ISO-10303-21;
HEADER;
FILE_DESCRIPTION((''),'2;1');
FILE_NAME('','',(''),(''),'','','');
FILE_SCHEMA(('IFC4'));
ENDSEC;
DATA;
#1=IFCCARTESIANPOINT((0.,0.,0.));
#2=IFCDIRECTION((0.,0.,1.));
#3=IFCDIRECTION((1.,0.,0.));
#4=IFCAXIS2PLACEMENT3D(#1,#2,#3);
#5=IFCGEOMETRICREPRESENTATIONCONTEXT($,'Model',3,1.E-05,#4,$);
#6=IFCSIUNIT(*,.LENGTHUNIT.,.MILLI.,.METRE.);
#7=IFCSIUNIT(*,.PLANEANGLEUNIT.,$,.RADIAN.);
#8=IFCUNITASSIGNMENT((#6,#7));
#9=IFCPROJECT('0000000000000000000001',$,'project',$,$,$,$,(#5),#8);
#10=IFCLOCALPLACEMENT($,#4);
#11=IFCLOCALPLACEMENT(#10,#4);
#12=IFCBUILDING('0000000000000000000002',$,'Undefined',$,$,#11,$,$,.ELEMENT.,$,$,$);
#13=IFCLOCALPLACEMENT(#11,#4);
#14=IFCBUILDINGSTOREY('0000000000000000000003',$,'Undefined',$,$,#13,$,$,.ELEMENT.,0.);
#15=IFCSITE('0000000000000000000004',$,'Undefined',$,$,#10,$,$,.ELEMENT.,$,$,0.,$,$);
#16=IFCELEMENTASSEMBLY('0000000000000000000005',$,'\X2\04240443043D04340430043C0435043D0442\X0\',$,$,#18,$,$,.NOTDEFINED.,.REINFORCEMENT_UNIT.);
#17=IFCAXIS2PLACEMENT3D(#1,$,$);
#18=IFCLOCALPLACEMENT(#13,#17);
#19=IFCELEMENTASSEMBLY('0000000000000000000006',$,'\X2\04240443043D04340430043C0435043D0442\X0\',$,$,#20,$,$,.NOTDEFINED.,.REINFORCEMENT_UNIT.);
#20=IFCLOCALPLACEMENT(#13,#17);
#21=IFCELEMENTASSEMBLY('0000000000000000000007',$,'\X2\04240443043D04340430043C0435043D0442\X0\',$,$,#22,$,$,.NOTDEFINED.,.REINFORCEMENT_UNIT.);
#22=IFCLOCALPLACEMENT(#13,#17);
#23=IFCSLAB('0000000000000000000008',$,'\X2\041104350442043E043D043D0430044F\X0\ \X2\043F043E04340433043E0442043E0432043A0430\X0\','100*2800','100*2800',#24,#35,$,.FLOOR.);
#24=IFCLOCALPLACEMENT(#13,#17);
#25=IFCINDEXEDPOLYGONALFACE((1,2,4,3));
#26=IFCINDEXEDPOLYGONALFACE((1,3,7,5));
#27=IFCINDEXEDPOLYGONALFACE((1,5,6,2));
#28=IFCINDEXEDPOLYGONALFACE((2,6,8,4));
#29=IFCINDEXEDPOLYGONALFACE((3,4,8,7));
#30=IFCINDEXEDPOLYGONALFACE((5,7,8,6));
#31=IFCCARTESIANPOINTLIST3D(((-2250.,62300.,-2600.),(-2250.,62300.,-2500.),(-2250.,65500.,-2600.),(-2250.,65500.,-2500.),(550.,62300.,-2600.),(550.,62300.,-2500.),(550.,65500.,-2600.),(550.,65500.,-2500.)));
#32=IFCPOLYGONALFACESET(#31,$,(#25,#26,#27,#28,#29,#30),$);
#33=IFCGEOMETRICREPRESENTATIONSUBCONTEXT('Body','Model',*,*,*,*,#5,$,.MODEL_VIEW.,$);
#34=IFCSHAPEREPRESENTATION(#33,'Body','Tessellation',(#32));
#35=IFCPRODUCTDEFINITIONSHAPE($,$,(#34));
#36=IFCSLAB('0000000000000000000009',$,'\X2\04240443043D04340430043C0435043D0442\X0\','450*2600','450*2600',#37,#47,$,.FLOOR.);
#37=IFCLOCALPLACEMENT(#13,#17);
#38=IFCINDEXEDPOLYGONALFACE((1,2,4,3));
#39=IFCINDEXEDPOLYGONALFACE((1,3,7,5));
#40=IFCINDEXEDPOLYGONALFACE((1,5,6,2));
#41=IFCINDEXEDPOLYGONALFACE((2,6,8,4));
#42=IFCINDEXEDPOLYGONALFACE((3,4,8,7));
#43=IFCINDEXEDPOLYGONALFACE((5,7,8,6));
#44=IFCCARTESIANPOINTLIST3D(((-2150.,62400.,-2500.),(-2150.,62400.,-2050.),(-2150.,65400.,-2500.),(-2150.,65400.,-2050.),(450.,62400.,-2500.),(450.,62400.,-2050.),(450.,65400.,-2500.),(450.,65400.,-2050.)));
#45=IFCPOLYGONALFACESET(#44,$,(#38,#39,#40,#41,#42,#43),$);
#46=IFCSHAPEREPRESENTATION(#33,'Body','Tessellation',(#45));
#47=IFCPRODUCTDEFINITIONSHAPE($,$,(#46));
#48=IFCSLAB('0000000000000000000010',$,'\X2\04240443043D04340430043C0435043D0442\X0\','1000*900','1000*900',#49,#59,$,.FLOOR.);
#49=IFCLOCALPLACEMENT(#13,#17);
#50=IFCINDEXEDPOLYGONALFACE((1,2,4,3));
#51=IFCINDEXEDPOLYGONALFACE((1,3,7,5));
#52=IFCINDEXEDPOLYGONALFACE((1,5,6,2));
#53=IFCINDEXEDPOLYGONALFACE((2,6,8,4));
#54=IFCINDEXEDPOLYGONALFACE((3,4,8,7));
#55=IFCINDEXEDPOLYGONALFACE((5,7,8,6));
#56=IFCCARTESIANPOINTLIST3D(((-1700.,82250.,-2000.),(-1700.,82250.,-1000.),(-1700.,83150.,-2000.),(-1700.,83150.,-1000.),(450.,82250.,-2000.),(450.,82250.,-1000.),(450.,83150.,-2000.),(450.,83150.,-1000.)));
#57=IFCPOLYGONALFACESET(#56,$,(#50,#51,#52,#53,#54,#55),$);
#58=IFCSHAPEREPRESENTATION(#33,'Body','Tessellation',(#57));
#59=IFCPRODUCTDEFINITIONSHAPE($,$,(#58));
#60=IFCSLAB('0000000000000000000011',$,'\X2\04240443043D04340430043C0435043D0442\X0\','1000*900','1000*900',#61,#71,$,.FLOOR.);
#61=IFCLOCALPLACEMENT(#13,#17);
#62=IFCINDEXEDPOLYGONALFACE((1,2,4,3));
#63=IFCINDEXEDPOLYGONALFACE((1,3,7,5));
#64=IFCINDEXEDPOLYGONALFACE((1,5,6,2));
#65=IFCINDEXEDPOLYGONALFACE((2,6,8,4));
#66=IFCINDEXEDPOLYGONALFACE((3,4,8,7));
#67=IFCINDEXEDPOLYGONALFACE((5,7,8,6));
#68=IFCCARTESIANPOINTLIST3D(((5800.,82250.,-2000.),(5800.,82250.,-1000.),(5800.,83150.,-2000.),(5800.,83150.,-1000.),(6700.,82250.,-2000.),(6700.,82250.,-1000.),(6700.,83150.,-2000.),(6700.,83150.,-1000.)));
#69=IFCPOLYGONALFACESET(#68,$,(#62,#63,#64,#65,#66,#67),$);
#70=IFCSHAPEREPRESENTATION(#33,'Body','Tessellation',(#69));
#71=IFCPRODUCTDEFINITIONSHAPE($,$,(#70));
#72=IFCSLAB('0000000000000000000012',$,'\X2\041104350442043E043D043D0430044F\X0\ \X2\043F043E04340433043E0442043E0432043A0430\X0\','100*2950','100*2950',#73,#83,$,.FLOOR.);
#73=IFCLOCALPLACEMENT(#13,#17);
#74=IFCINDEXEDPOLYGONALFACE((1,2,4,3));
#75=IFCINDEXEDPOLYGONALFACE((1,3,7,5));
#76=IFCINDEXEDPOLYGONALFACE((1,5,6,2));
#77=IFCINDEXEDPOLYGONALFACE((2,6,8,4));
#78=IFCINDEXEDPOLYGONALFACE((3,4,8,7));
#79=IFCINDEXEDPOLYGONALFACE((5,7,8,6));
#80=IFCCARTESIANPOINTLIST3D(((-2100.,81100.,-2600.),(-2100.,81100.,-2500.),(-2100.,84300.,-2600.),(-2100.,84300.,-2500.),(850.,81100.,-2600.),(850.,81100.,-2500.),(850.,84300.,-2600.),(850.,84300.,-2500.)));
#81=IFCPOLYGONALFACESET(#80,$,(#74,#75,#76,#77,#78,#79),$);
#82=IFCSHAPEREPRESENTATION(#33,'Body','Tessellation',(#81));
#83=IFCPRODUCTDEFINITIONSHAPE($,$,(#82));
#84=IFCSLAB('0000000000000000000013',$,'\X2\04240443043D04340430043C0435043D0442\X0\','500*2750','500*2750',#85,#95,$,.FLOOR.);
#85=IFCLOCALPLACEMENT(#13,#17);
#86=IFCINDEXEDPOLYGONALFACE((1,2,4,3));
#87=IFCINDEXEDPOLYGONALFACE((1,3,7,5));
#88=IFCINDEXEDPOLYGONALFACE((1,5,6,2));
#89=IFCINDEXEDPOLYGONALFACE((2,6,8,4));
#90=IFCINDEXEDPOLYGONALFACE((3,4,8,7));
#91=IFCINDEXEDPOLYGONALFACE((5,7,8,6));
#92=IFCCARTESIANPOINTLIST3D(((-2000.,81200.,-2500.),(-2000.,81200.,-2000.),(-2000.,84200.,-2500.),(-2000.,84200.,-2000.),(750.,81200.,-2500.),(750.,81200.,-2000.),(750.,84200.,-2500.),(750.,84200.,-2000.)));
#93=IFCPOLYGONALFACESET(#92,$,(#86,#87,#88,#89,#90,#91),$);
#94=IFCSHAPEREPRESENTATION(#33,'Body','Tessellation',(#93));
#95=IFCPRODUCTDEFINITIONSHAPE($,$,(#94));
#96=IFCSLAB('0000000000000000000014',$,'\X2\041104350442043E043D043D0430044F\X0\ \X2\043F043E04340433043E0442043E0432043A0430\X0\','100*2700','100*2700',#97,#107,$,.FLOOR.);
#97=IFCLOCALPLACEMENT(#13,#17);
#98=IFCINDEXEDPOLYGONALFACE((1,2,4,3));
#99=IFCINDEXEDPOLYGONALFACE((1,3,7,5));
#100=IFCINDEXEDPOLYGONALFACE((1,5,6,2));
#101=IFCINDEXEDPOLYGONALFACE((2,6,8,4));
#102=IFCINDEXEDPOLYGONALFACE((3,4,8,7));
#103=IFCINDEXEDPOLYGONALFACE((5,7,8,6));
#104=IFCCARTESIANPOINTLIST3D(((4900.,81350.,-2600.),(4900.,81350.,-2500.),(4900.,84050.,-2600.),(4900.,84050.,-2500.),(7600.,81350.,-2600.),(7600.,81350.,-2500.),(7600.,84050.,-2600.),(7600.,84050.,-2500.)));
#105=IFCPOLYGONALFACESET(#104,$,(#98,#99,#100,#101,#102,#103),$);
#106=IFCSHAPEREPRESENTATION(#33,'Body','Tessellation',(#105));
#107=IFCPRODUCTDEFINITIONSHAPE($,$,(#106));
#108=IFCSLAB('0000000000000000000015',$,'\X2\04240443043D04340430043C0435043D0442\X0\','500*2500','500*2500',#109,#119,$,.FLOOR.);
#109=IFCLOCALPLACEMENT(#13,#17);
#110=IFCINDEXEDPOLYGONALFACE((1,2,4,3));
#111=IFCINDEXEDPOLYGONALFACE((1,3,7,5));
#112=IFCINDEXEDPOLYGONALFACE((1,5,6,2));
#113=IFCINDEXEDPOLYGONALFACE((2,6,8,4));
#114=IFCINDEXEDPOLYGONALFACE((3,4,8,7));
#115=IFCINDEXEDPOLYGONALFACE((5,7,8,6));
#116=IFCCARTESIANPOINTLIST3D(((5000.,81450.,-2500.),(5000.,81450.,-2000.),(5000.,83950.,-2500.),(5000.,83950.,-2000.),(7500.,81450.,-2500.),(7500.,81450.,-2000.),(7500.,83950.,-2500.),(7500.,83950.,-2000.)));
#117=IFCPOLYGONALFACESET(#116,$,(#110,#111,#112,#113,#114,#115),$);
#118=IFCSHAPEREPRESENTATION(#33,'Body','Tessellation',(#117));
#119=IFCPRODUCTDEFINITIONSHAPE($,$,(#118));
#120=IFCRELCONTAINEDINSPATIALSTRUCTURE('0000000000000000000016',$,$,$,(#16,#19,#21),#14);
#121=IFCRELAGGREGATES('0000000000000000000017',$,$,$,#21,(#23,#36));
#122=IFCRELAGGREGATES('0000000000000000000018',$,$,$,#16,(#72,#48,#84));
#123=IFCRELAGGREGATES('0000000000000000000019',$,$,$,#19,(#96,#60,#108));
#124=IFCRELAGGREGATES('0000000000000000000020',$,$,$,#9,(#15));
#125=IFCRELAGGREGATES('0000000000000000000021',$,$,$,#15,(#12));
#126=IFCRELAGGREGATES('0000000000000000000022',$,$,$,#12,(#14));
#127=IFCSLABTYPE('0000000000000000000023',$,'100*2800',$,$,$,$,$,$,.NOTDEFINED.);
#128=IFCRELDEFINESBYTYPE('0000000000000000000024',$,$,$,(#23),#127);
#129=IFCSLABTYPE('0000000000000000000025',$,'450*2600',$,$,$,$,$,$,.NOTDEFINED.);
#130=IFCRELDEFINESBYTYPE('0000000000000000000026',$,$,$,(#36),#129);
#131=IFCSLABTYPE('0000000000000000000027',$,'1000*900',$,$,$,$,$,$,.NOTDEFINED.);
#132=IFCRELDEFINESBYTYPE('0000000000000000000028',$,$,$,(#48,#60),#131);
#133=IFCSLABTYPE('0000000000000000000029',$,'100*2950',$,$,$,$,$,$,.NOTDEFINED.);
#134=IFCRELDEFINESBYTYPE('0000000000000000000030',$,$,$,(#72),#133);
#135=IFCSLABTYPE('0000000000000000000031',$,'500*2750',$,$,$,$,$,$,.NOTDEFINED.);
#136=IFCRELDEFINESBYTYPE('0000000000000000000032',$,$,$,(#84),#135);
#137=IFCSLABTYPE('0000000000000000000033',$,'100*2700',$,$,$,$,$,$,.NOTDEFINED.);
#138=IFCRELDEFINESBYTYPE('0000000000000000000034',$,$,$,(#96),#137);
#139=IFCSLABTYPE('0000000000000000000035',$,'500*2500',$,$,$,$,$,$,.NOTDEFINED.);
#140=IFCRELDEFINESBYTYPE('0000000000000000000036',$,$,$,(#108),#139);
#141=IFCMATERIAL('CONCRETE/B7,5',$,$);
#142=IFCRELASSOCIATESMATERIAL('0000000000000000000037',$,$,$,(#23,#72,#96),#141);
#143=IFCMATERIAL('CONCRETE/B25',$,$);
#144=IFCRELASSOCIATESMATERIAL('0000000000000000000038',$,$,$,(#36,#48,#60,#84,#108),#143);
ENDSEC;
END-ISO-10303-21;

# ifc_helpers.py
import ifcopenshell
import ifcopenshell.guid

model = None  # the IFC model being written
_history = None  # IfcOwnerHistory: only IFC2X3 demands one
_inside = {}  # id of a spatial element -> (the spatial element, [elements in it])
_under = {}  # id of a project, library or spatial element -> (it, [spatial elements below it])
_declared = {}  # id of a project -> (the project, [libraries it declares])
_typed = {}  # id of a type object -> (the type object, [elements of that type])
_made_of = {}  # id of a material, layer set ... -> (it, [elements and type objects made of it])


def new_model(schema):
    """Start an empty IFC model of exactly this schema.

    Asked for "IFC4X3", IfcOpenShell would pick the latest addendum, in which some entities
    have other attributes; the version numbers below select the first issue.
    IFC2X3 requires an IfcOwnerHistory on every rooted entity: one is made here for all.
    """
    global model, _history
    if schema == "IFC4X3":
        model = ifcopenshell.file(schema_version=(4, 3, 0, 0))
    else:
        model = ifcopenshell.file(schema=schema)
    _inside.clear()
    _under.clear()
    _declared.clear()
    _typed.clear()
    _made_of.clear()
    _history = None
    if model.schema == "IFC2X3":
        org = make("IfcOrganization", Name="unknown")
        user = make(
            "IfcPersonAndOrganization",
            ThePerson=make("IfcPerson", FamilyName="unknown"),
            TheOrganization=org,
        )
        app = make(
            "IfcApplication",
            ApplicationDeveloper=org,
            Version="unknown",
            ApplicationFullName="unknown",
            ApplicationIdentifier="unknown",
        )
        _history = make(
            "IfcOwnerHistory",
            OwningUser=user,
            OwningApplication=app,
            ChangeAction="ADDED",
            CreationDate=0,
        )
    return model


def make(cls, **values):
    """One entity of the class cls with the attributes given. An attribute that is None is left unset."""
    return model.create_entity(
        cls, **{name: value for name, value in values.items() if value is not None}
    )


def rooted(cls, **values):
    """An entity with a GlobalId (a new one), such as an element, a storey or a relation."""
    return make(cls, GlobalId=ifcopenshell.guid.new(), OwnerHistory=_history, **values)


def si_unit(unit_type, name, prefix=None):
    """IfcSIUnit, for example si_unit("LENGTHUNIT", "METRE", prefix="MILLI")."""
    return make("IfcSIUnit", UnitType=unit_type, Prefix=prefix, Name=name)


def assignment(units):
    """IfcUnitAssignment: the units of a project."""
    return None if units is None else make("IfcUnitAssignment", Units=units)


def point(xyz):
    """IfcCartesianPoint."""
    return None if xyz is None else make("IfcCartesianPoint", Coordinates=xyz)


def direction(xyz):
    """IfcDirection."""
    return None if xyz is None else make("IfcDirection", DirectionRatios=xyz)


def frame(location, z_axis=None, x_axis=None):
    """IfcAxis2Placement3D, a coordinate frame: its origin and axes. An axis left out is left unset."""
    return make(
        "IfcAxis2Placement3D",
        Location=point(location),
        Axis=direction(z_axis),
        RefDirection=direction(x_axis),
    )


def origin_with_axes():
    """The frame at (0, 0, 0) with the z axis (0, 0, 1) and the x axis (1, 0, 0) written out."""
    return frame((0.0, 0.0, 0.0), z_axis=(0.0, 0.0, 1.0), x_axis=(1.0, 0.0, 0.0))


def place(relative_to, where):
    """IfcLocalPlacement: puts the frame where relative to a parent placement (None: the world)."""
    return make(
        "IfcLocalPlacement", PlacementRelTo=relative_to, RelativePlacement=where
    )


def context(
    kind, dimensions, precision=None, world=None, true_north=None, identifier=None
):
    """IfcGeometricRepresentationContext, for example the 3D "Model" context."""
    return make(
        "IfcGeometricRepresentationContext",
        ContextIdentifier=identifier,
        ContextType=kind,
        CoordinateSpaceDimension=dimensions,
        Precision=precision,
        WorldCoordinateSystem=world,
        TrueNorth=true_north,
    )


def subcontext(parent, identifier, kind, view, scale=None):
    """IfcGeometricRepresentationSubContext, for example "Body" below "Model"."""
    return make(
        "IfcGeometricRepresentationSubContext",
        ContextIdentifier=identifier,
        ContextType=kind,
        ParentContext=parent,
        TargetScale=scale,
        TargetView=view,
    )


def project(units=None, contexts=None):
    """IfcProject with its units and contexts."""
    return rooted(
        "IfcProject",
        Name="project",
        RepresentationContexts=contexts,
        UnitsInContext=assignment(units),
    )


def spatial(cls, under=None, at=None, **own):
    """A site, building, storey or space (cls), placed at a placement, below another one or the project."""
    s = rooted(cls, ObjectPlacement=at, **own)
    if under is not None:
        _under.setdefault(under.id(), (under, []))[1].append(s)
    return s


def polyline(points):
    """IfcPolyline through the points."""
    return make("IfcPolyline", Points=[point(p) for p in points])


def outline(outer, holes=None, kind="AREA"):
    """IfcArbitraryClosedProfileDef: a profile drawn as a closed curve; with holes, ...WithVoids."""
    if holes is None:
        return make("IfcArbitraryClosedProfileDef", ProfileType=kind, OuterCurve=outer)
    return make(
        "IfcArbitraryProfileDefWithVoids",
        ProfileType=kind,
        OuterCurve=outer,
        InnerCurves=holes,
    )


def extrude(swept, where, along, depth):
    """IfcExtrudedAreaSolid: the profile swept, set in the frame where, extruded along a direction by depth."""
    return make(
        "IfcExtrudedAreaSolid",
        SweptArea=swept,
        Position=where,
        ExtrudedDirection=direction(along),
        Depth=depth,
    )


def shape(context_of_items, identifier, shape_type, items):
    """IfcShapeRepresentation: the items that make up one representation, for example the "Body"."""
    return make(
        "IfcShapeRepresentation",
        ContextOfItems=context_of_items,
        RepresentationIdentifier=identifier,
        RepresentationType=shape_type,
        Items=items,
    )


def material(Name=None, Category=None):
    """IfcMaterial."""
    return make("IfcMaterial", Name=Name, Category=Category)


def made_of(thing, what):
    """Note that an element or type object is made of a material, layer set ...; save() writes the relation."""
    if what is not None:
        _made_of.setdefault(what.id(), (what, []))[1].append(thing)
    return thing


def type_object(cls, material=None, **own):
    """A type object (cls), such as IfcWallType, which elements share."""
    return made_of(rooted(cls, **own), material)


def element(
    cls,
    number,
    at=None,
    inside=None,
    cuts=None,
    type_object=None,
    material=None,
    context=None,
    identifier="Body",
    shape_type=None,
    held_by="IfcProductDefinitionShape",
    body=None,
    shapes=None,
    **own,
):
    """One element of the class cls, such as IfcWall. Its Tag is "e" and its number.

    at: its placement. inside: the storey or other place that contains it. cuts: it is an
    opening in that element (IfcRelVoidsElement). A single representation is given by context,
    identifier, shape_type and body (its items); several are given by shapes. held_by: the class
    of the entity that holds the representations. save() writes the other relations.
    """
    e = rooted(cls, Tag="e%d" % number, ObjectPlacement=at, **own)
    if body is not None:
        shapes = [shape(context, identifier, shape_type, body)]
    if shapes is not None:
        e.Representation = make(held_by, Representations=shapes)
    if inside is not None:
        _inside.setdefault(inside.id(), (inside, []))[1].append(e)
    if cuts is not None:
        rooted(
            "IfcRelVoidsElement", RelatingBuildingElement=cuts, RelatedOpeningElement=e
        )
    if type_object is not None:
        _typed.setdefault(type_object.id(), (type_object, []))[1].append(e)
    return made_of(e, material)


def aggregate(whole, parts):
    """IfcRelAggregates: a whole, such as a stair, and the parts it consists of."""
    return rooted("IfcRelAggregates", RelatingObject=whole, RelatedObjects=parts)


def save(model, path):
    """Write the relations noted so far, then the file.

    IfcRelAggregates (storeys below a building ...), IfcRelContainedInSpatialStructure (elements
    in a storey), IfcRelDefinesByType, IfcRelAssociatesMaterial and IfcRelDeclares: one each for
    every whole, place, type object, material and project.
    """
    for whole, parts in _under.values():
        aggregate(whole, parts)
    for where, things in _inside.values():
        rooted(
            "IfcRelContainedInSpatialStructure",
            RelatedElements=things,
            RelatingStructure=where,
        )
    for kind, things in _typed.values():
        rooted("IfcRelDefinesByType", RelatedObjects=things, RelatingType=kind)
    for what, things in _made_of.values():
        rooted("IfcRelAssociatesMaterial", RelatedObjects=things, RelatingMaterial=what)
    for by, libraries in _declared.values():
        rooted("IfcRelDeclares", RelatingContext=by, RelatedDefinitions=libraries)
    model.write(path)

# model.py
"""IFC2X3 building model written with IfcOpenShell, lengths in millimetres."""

from ifc_helpers import new_model, si_unit, frame, origin_with_axes, place, context, subcontext, project, spatial, polyline, outline, extrude, material, type_object, element, aggregate, save


model = new_model("IFC2X3")

# Units and contexts
model_context = context("Model", 3, precision=1e-05, world=origin_with_axes())
body_context = subcontext(model_context, "Body", "Model", "MODEL_VIEW")
ifc_project = project(units=[si_unit("LENGTHUNIT", "METRE", prefix="MILLI"), si_unit("PLANEANGLEUNIT", "RADIAN")], contexts=[model_context])

# Site, building, storey
site_placement = place(None, origin_with_axes())
site = spatial("IfcSite", under=ifc_project, at=site_placement, Name="Undefined", CompositionType="ELEMENT", RefElevation=0.0)
building_placement = place(site_placement, origin_with_axes())
building = spatial("IfcBuilding", under=site, at=building_placement, Name="Undefined", CompositionType="ELEMENT")
storey_placement = place(building_placement, origin_with_axes())
storey = spatial("IfcBuildingStorey", under=building, at=storey_placement, Name="Undefined", CompositionType="ELEMENT", Elevation=0.0)

# Element assemblies
assembly_1_placement = place(storey_placement, origin_with_axes())
assembly_1 = element("IfcElementAssembly", 1, at=assembly_1_placement, inside=storey, Name="Фундамент", AssemblyPlace="NOTDEFINED", PredefinedType="REINFORCEMENT_UNIT")
ifc_material_1 = material(Name="CONCRETE/B25")
assembly_2_placement = place(storey_placement, origin_with_axes())
assembly_2 = element("IfcElementAssembly", 2, at=assembly_2_placement, inside=storey, Name="Фундамент", AssemblyPlace="NOTDEFINED", PredefinedType="REINFORCEMENT_UNIT")

# Shared definitions
ifc_material_2 = material(Name="CONCRETE/B7,5")

# Element assembly, slabs
assembly_3_placement = place(storey_placement, origin_with_axes())
assembly_3 = element("IfcElementAssembly", 3, at=assembly_3_placement, inside=storey, Name="Фундамент", AssemblyPlace="NOTDEFINED", PredefinedType="REINFORCEMENT_UNIT")
slab_type_1 = type_object("IfcSlabType", Name="100*2800", PredefinedType="NOTDEFINED")
slab_1_placement = place(assembly_3_placement, frame((-2250.0, 65500.0, -2550.0), z_axis=(0.0, 0.0, 1.0), x_axis=(0.0, -1.0, 0.0)))
slab_1 = element("IfcSlab", 4, at=slab_1_placement, type_object=slab_type_1, material=ifc_material_2, Name="Бетонная подготовка", Description="100*2800", ObjectType="100*2800", PredefinedType="FLOOR", context=body_context, shape_type="SweptSolid", body=[
    extrude(outline(polyline([(0.0, 0.0), (3200.0, 0.0), (3200.0, 2800.0), (0.0, 2800.0), (0.0, 0.0)])), frame((0.0, 0.0, -50.0), z_axis=(0.0, 0.0, 1.0), x_axis=(1.0, 0.0, 0.0)), (0.0, 0.0, 1.0), 100.0),
])
slab_type_2 = type_object("IfcSlabType", Name="450*2600", PredefinedType="NOTDEFINED")
slab_2_placement = place(assembly_3_placement, frame((-2150.0, 65400.0, -2275.0), z_axis=(0.0, 0.0, 1.0), x_axis=(0.0, -1.0, 0.0)))
slab_2 = element("IfcSlab", 5, at=slab_2_placement, type_object=slab_type_2, material=ifc_material_1, Name="Фундамент", Description="450*2600", ObjectType="450*2600", PredefinedType="FLOOR", context=body_context, shape_type="SweptSolid", body=[
    extrude(outline(polyline([(0.0, 0.0), (3000.0, 0.0), (3000.0, 2600.0), (0.0, 2600.0), (0.0, 0.0)])), frame((0.0, 0.0, -225.0), z_axis=(0.0, 0.0, 1.0), x_axis=(1.0, 0.0, 0.0)), (0.0, 0.0, 1.0), 450.0),
])
aggregate(assembly_3, [slab_1, slab_2])

# Slabs
slab_type_3 = type_object("IfcSlabType", Name="1000*900", PredefinedType="NOTDEFINED")
slab_3_placement = place(assembly_1_placement, frame((-1700.0, 83150.0, -1500.0), z_axis=(0.0, 0.0, 1.0), x_axis=(0.0, -1.0, 0.0)))
slab_3 = element("IfcSlab", 6, at=slab_3_placement, type_object=slab_type_3, material=ifc_material_1, Name="Фундамент", Description="1000*900", ObjectType="1000*900", PredefinedType="FLOOR", context=body_context, shape_type="SweptSolid", body=[
    extrude(outline(polyline([(0.0, 0.0), (900.0, 0.0), (900.0, 2150.0), (0.0, 2150.0), (0.0, 0.0)])), frame((0.0, 0.0, -500.0), z_axis=(0.0, 0.0, 1.0), x_axis=(1.0, 0.0, 0.0)), (0.0, 0.0, 1.0), 1000.0),
])
slab_4_placement = place(assembly_2_placement, frame((5800.0, 83150.0, -1500.0), z_axis=(0.0, 0.0, 1.0), x_axis=(0.0, -1.0, 0.0)))
slab_4 = element("IfcSlab", 7, at=slab_4_placement, type_object=slab_type_3, material=ifc_material_1, Name="Фундамент", Description="1000*900", ObjectType="1000*900", PredefinedType="FLOOR", context=body_context, shape_type="SweptSolid", body=[
    extrude(outline(polyline([(0.0, 0.0), (900.0, 0.0), (900.0, 900.0), (0.0, 900.0), (0.0, 0.0)])), frame((0.0, 0.0, -500.0), z_axis=(0.0, 0.0, 1.0), x_axis=(1.0, 0.0, 0.0)), (0.0, 0.0, 1.0), 1000.0),
])
slab_type_4 = type_object("IfcSlabType", Name="100*2950", PredefinedType="NOTDEFINED")
slab_5_placement = place(assembly_1_placement, frame((-2100.0, 84300.0, -2550.0), z_axis=(0.0, 0.0, 1.0), x_axis=(0.0, -1.0, 0.0)))
slab_5 = element("IfcSlab", 8, at=slab_5_placement, type_object=slab_type_4, material=ifc_material_2, Name="Бетонная подготовка", Description="100*2950", ObjectType="100*2950", PredefinedType="FLOOR", context=body_context, shape_type="SweptSolid", body=[
    extrude(outline(polyline([(0.0, 0.0), (3200.0, 0.0), (3200.0, 2950.0), (0.0, 2950.0), (0.0, 0.0)])), frame((0.0, 0.0, -50.0), z_axis=(0.0, 0.0, 1.0), x_axis=(1.0, 0.0, 0.0)), (0.0, 0.0, 1.0), 100.0),
])
slab_type_5 = type_object("IfcSlabType", Name="500*2750", PredefinedType="NOTDEFINED")
slab_6_placement = place(assembly_1_placement, frame((-2000.0, 84200.0, -2250.0), z_axis=(0.0, 0.0, 1.0), x_axis=(0.0, -1.0, 0.0)))
slab_6 = element("IfcSlab", 9, at=slab_6_placement, type_object=slab_type_5, material=ifc_material_1, Name="Фундамент", Description="500*2750", ObjectType="500*2750", PredefinedType="FLOOR", context=body_context, shape_type="SweptSolid", body=[
    extrude(outline(polyline([(0.0, 0.0), (3000.0, 0.0), (3000.0, 2750.0), (0.0, 2750.0), (0.0, 0.0)])), frame((0.0, 0.0, -250.0), z_axis=(0.0, 0.0, 1.0), x_axis=(1.0, 0.0, 0.0)), (0.0, 0.0, 1.0), 500.0),
])
aggregate(assembly_1, [slab_5, slab_3, slab_6])
slab_type_6 = type_object("IfcSlabType", Name="100*2700", PredefinedType="NOTDEFINED")
slab_7_placement = place(assembly_2_placement, frame((4900.0, 84050.0, -2550.0), z_axis=(0.0, 0.0, 1.0), x_axis=(0.0, -1.0, 0.0)))
slab_7 = element("IfcSlab", 10, at=slab_7_placement, type_object=slab_type_6, material=ifc_material_2, Name="Бетонная подготовка", Description="100*2700", ObjectType="100*2700", PredefinedType="FLOOR", context=body_context, shape_type="SweptSolid", body=[
    extrude(outline(polyline([(0.0, 0.0), (2700.0, 0.0), (2700.0, 2700.0), (0.0, 2700.0), (0.0, 0.0)])), frame((0.0, 0.0, -50.0), z_axis=(0.0, 0.0, 1.0), x_axis=(1.0, 0.0, 0.0)), (0.0, 0.0, 1.0), 100.0),
])
slab_type_7 = type_object("IfcSlabType", Name="500*2500", PredefinedType="NOTDEFINED")
slab_8_placement = place(assembly_2_placement, frame((5000.0, 83950.0, -2250.0), z_axis=(0.0, 0.0, 1.0), x_axis=(0.0, -1.0, 0.0)))
slab_8 = element("IfcSlab", 11, at=slab_8_placement, type_object=slab_type_7, material=ifc_material_1, Name="Фундамент", Description="500*2500", ObjectType="500*2500", PredefinedType="FLOOR", context=body_context, shape_type="SweptSolid", body=[
    extrude(outline(polyline([(0.0, 0.0), (2500.0, 0.0), (2500.0, 2500.0), (0.0, 2500.0), (0.0, 0.0)])), frame((0.0, 0.0, -250.0), z_axis=(0.0, 0.0, 1.0), x_axis=(1.0, 0.0, 0.0)), (0.0, 0.0, 1.0), 500.0),
])
aggregate(assembly_2, [slab_7, slab_4, slab_8])

save(model, "model.ifc")
